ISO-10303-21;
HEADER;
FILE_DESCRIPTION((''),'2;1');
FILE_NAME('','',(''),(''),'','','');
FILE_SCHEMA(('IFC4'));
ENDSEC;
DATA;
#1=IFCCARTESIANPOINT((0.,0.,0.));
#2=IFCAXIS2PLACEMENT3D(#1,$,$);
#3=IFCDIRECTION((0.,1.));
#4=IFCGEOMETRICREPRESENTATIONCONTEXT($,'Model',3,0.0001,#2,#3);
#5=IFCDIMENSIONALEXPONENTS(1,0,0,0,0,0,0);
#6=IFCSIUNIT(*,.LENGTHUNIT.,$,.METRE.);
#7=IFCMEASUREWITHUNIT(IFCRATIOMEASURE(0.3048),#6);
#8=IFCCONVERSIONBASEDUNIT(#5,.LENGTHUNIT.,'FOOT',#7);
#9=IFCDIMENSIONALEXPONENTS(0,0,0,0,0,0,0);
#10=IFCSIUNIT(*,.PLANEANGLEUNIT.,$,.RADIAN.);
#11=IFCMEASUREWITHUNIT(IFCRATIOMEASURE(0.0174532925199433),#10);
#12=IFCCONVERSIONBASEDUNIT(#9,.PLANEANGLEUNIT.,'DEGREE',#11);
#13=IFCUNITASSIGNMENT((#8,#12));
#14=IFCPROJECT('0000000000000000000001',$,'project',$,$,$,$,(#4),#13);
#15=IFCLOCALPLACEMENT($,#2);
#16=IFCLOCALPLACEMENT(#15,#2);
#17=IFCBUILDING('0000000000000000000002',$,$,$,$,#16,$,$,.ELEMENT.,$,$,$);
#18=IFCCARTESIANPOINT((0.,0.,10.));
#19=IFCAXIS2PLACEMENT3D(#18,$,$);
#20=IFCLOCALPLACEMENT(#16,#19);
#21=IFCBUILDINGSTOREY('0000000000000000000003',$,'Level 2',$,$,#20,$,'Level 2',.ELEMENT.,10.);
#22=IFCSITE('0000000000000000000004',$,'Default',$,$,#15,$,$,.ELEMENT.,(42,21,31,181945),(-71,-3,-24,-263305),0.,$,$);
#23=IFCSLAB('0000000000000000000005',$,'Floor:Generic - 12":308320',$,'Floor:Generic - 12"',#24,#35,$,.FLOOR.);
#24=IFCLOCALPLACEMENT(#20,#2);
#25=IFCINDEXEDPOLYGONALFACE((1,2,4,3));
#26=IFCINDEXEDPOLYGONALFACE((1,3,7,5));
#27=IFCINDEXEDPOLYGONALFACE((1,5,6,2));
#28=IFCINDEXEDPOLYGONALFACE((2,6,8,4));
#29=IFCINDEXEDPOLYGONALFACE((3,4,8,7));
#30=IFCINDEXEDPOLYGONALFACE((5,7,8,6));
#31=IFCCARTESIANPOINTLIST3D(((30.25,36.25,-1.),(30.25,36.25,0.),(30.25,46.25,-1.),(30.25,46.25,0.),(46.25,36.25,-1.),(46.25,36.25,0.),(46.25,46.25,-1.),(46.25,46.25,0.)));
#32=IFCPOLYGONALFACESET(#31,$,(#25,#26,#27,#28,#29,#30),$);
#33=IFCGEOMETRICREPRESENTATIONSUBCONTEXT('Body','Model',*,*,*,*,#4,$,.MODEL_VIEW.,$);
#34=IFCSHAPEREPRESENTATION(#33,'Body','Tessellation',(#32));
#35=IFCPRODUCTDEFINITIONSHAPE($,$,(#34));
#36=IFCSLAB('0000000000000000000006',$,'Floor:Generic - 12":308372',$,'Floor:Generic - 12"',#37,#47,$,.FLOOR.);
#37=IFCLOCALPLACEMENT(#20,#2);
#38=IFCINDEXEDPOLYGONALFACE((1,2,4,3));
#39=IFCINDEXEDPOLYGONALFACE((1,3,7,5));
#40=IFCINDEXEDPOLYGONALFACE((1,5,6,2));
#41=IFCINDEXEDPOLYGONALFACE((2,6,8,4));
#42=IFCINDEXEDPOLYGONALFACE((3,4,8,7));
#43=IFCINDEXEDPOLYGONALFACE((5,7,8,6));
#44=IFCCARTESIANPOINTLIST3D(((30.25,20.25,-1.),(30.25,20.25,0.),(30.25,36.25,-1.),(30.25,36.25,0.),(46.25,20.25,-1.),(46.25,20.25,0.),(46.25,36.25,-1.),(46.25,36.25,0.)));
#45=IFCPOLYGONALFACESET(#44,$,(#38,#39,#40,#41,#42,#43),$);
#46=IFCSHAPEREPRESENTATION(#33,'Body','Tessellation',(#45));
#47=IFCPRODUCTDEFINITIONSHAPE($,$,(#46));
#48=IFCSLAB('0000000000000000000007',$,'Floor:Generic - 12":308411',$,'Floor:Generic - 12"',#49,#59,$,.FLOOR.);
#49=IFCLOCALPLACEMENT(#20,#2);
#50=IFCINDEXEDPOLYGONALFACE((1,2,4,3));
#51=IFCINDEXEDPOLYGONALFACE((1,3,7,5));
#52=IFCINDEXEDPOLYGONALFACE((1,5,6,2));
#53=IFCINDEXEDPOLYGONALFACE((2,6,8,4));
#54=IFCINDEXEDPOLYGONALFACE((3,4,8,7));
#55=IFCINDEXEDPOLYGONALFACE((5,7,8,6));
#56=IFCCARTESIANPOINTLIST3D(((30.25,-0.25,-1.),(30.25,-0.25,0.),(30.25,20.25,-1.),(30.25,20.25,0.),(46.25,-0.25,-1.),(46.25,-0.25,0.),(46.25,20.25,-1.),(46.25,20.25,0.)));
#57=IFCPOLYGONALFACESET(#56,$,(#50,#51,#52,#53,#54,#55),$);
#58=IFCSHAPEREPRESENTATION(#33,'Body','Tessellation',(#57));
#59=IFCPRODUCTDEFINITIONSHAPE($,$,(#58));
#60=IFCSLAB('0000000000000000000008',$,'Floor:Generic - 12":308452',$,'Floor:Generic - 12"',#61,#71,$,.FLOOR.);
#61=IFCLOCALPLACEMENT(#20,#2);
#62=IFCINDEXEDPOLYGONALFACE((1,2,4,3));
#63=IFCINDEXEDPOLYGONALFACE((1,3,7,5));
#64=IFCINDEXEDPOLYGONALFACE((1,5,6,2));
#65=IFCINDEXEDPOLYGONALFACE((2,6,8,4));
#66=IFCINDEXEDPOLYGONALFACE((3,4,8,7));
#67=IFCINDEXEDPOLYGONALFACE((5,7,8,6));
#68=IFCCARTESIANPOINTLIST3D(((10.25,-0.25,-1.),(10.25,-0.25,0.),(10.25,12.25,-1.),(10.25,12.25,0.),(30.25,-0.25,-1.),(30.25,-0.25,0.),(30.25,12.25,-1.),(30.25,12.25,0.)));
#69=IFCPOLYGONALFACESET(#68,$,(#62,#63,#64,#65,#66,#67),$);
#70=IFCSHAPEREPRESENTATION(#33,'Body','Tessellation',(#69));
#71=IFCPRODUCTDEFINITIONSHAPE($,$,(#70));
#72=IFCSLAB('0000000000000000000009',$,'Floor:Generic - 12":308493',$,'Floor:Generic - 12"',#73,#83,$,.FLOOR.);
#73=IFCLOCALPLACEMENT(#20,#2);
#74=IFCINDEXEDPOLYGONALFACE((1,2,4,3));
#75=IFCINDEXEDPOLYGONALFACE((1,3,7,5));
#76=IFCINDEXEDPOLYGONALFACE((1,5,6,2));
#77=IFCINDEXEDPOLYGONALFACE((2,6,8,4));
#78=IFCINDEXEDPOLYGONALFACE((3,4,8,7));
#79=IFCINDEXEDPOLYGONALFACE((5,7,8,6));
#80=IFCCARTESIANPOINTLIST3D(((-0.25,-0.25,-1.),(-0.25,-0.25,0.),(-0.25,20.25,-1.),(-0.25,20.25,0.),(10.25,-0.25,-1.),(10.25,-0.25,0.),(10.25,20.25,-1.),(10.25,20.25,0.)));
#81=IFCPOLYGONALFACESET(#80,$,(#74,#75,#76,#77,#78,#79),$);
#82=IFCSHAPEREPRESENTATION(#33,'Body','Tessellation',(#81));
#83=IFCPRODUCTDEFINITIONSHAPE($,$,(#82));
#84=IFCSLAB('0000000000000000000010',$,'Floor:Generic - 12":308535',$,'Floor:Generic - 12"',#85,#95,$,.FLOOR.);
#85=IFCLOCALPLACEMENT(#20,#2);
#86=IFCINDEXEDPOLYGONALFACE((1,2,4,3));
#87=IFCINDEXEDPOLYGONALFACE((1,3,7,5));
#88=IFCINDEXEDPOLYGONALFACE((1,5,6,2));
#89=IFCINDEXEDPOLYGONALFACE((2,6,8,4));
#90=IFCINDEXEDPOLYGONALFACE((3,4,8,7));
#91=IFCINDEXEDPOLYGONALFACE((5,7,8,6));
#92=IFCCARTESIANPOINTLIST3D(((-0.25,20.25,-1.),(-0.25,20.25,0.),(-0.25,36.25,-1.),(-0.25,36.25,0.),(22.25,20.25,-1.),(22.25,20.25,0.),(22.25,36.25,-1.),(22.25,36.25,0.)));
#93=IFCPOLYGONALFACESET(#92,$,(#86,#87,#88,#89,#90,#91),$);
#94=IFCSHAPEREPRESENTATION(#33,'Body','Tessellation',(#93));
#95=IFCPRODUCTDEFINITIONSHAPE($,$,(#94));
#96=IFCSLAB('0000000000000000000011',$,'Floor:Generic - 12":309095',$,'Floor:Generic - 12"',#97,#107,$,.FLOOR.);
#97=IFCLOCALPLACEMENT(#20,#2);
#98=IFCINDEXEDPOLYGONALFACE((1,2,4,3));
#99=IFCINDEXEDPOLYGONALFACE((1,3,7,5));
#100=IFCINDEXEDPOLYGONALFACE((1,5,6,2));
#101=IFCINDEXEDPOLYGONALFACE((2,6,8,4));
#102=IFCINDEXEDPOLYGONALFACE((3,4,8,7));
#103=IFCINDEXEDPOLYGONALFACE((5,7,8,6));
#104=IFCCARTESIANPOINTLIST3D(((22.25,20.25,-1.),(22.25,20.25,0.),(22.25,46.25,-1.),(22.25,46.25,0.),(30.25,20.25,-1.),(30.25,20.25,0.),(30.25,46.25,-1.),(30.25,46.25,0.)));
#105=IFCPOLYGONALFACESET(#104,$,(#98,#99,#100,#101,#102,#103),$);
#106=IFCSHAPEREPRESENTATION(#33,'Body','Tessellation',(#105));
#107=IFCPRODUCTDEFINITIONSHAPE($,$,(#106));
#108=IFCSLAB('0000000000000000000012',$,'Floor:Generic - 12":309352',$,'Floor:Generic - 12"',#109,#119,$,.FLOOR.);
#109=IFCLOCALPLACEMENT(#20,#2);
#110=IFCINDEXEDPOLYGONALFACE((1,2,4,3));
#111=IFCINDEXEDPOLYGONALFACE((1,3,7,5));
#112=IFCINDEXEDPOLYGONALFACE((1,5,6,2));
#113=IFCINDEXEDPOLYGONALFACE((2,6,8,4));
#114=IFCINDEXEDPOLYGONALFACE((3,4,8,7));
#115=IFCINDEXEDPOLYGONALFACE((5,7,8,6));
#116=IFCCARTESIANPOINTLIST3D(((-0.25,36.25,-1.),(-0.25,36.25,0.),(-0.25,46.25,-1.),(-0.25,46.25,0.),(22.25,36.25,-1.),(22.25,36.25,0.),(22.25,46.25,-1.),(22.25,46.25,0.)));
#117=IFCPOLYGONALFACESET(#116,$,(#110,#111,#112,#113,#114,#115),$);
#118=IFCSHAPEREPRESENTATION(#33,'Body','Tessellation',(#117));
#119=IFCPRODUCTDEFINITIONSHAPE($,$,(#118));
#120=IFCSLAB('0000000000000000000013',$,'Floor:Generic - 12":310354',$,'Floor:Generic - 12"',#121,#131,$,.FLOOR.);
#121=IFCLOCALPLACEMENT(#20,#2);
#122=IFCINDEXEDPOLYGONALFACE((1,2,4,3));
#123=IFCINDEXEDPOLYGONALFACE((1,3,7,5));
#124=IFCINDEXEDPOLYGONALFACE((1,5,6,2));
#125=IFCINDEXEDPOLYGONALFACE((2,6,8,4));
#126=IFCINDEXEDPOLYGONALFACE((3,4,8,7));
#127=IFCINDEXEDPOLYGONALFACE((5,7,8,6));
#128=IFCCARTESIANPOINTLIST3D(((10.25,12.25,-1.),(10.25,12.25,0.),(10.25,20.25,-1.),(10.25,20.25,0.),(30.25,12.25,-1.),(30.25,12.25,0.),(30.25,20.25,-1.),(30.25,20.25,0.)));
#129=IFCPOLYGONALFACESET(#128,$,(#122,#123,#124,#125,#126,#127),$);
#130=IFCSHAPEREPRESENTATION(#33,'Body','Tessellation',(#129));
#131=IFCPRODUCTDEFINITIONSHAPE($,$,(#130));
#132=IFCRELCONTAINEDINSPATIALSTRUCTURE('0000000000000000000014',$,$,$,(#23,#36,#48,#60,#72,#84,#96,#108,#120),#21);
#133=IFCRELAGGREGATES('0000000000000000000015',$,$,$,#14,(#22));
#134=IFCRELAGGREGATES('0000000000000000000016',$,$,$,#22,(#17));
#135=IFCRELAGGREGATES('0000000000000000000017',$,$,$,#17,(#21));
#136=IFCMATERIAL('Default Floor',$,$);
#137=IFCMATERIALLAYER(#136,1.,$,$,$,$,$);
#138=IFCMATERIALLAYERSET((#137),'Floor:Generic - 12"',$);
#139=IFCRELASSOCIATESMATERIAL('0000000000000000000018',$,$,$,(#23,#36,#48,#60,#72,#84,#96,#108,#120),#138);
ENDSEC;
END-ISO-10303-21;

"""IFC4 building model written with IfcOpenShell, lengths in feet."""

from ifc_helpers import new_model, entity, si_unit, converted_unit, direction, frame, frame_2d, origin, place, context, subcontext, project, spatial, rectangle, extrude, material, layer, layer_set, layer_usage, element, save


model = new_model("IFC4")

# Units and contexts
model_context = context("Model", 3, precision=0.0001, world=origin(), true_north=direction((0.0, 1.0)))
body_context = subcontext(model_context, "Body", "Model", "MODEL_VIEW")
ifc_project = project(units=[converted_unit("LENGTHUNIT", "FOOT", entity("IfcRatioMeasure", 0.3048), si_unit("LENGTHUNIT", "METRE"), dimensions=[1, 0, 0, 0, 0, 0, 0]), converted_unit("PLANEANGLEUNIT", "DEGREE", entity("IfcRatioMeasure", 0.0174532925199433), si_unit("PLANEANGLEUNIT", "RADIAN"), dimensions=[0, 0, 0, 0, 0, 0, 0])], contexts=[model_context])

# Site, building, storey
site_placement = place(None, origin())
site = spatial("IfcSite", under=ifc_project, at=site_placement, Name="Default", CompositionType="ELEMENT", RefLatitude=(42, 21, 31, 181945), RefLongitude=(-71, -3, -24, -263305), RefElevation=0.0)
building_placement = place(site_placement, origin())
building = spatial("IfcBuilding", under=site, at=building_placement, CompositionType="ELEMENT")
storey_placement = place(building_placement, frame((0.0, 0.0, 10.0)))
storey = spatial("IfcBuildingStorey", under=building, at=storey_placement, Name="Level 2", LongName="Level 2", CompositionType="ELEMENT", Elevation=10.0)

# Slabs
ifc_material = material(Name="Default Floor")
ifc_layer = layer(ifc_material, 1.0)
ifc_layer_set = layer_set([ifc_layer], Name="Floor:Generic - 12\"")
ifc_layer_usage_1 = layer_usage(ifc_layer_set, "AXIS3", "POSITIVE", 0.0)
slab_1_placement = place(storey_placement, origin())
element("IfcSlab", 1, at=slab_1_placement, inside=storey, material=ifc_layer_usage_1, Name="Floor:Generic - 12\":308320", ObjectType="Floor:Generic - 12\"", PredefinedType="FLOOR", context=body_context, shape_type="SweptSolid", body=[
    extrude(rectangle(XDim=10.0, YDim=16.0, at=frame_2d((0.0, 0.0), x_axis=(1.0, 0.0))), frame((38.25, 41.25, 0.0), z_axis=(0.0, 0.0, -1.0), x_axis=(0.0, 1.0, 0.0)), (0.0, 0.0, 1.0), 1.0),
])
ifc_layer_usage_2 = layer_usage(ifc_layer_set, "AXIS3", "POSITIVE", 0.0)
slab_2_placement = place(storey_placement, origin())
element("IfcSlab", 2, at=slab_2_placement, inside=storey, material=ifc_layer_usage_2, Name="Floor:Generic - 12\":308372", ObjectType="Floor:Generic - 12\"", PredefinedType="FLOOR", context=body_context, shape_type="SweptSolid", body=[
    extrude(rectangle(XDim=16.0, YDim=16.0, at=frame_2d((0.0, 0.0), x_axis=(1.0, 0.0))), frame((38.25, 28.25, 0.0), z_axis=(0.0, 0.0, -1.0), x_axis=(0.0, 1.0, 0.0)), (0.0, 0.0, 1.0), 1.0),
])
ifc_layer_usage_3 = layer_usage(ifc_layer_set, "AXIS3", "POSITIVE", 0.0)
slab_3_placement = place(storey_placement, origin())
element("IfcSlab", 3, at=slab_3_placement, inside=storey, material=ifc_layer_usage_3, Name="Floor:Generic - 12\":308411", ObjectType="Floor:Generic - 12\"", PredefinedType="FLOOR", context=body_context, shape_type="SweptSolid", body=[
    extrude(rectangle(XDim=20.5, YDim=16.0, at=frame_2d((0.0, 0.0), x_axis=(1.0, 0.0))), frame((38.25, 10.0, 0.0), z_axis=(0.0, 0.0, -1.0), x_axis=(0.0, 1.0, 0.0)), (0.0, 0.0, 1.0), 1.0),
])
ifc_layer_usage_4 = layer_usage(ifc_layer_set, "AXIS3", "POSITIVE", 0.0)
slab_4_placement = place(storey_placement, origin())
element("IfcSlab", 4, at=slab_4_placement, inside=storey, material=ifc_layer_usage_4, Name="Floor:Generic - 12\":308452", ObjectType="Floor:Generic - 12\"", PredefinedType="FLOOR", context=body_context, shape_type="SweptSolid", body=[
    extrude(rectangle(XDim=12.5, YDim=20.0, at=frame_2d((0.0, 0.0), x_axis=(1.0, 0.0))), frame((20.25, 6.0, 0.0), z_axis=(0.0, 0.0, -1.0), x_axis=(0.0, 1.0, 0.0)), (0.0, 0.0, 1.0), 1.0),
])
ifc_layer_usage_5 = layer_usage(ifc_layer_set, "AXIS3", "POSITIVE", 0.0)
slab_5_placement = place(storey_placement, origin())
element("IfcSlab", 5, at=slab_5_placement, inside=storey, material=ifc_layer_usage_5, Name="Floor:Generic - 12\":308493", ObjectType="Floor:Generic - 12\"", PredefinedType="FLOOR", context=body_context, shape_type="SweptSolid", body=[
    extrude(rectangle(XDim=20.5, YDim=10.5, at=frame_2d((0.0, 0.0), x_axis=(1.0, 0.0))), frame((5.0, 10.0, 0.0), z_axis=(0.0, 0.0, -1.0), x_axis=(0.0, 1.0, 0.0)), (0.0, 0.0, 1.0), 1.0),
])
ifc_layer_usage_6 = layer_usage(ifc_layer_set, "AXIS3", "POSITIVE", 0.0)
slab_6_placement = place(storey_placement, origin())
element("IfcSlab", 6, at=slab_6_placement, inside=storey, material=ifc_layer_usage_6, Name="Floor:Generic - 12\":308535", ObjectType="Floor:Generic - 12\"", PredefinedType="FLOOR", context=body_context, shape_type="SweptSolid", body=[
    extrude(rectangle(XDim=16.0, YDim=22.5, at=frame_2d((0.0, 0.0), x_axis=(1.0, 0.0))), frame((11.0, 28.25, 0.0), z_axis=(0.0, 0.0, -1.0), x_axis=(0.0, 1.0, 0.0)), (0.0, 0.0, 1.0), 1.0),
])
ifc_layer_usage_7 = layer_usage(ifc_layer_set, "AXIS3", "POSITIVE", 0.0)
slab_7_placement = place(storey_placement, origin())
element("IfcSlab", 7, at=slab_7_placement, inside=storey, material=ifc_layer_usage_7, Name="Floor:Generic - 12\":309095", ObjectType="Floor:Generic - 12\"", PredefinedType="FLOOR", context=body_context, shape_type="SweptSolid", body=[
    extrude(rectangle(XDim=26.0, YDim=8.0, at=frame_2d((0.0, 0.0), x_axis=(1.0, 0.0))), frame((26.25, 33.25, 0.0), z_axis=(0.0, 0.0, -1.0), x_axis=(0.0, 1.0, 0.0)), (0.0, 0.0, 1.0), 1.0),
])
ifc_layer_usage_8 = layer_usage(ifc_layer_set, "AXIS3", "POSITIVE", 0.0)
slab_8_placement = place(storey_placement, origin())
element("IfcSlab", 8, at=slab_8_placement, inside=storey, material=ifc_layer_usage_8, Name="Floor:Generic - 12\":309352", ObjectType="Floor:Generic - 12\"", PredefinedType="FLOOR", context=body_context, shape_type="SweptSolid", body=[
    extrude(rectangle(XDim=10.0, YDim=22.5, at=frame_2d((0.0, 0.0), x_axis=(1.0, 0.0))), frame((11.0, 41.25, 0.0), z_axis=(0.0, 0.0, -1.0), x_axis=(0.0, 1.0, 0.0)), (0.0, 0.0, 1.0), 1.0),
])
ifc_layer_usage_9 = layer_usage(ifc_layer_set, "AXIS3", "POSITIVE", 0.0)
slab_9_placement = place(storey_placement, origin())
element("IfcSlab", 9, at=slab_9_placement, inside=storey, material=ifc_layer_usage_9, Name="Floor:Generic - 12\":310354", ObjectType="Floor:Generic - 12\"", PredefinedType="FLOOR", context=body_context, shape_type="SweptSolid", body=[
    extrude(rectangle(XDim=8.0, YDim=20.0, at=frame_2d((0.0, 0.0), x_axis=(1.0, 0.0))), frame((20.25, 16.25, 0.0), z_axis=(0.0, 0.0, -1.0), x_axis=(0.0, 1.0, 0.0)), (0.0, 0.0, 1.0), 1.0),
])

save(model, "model.ifc")
